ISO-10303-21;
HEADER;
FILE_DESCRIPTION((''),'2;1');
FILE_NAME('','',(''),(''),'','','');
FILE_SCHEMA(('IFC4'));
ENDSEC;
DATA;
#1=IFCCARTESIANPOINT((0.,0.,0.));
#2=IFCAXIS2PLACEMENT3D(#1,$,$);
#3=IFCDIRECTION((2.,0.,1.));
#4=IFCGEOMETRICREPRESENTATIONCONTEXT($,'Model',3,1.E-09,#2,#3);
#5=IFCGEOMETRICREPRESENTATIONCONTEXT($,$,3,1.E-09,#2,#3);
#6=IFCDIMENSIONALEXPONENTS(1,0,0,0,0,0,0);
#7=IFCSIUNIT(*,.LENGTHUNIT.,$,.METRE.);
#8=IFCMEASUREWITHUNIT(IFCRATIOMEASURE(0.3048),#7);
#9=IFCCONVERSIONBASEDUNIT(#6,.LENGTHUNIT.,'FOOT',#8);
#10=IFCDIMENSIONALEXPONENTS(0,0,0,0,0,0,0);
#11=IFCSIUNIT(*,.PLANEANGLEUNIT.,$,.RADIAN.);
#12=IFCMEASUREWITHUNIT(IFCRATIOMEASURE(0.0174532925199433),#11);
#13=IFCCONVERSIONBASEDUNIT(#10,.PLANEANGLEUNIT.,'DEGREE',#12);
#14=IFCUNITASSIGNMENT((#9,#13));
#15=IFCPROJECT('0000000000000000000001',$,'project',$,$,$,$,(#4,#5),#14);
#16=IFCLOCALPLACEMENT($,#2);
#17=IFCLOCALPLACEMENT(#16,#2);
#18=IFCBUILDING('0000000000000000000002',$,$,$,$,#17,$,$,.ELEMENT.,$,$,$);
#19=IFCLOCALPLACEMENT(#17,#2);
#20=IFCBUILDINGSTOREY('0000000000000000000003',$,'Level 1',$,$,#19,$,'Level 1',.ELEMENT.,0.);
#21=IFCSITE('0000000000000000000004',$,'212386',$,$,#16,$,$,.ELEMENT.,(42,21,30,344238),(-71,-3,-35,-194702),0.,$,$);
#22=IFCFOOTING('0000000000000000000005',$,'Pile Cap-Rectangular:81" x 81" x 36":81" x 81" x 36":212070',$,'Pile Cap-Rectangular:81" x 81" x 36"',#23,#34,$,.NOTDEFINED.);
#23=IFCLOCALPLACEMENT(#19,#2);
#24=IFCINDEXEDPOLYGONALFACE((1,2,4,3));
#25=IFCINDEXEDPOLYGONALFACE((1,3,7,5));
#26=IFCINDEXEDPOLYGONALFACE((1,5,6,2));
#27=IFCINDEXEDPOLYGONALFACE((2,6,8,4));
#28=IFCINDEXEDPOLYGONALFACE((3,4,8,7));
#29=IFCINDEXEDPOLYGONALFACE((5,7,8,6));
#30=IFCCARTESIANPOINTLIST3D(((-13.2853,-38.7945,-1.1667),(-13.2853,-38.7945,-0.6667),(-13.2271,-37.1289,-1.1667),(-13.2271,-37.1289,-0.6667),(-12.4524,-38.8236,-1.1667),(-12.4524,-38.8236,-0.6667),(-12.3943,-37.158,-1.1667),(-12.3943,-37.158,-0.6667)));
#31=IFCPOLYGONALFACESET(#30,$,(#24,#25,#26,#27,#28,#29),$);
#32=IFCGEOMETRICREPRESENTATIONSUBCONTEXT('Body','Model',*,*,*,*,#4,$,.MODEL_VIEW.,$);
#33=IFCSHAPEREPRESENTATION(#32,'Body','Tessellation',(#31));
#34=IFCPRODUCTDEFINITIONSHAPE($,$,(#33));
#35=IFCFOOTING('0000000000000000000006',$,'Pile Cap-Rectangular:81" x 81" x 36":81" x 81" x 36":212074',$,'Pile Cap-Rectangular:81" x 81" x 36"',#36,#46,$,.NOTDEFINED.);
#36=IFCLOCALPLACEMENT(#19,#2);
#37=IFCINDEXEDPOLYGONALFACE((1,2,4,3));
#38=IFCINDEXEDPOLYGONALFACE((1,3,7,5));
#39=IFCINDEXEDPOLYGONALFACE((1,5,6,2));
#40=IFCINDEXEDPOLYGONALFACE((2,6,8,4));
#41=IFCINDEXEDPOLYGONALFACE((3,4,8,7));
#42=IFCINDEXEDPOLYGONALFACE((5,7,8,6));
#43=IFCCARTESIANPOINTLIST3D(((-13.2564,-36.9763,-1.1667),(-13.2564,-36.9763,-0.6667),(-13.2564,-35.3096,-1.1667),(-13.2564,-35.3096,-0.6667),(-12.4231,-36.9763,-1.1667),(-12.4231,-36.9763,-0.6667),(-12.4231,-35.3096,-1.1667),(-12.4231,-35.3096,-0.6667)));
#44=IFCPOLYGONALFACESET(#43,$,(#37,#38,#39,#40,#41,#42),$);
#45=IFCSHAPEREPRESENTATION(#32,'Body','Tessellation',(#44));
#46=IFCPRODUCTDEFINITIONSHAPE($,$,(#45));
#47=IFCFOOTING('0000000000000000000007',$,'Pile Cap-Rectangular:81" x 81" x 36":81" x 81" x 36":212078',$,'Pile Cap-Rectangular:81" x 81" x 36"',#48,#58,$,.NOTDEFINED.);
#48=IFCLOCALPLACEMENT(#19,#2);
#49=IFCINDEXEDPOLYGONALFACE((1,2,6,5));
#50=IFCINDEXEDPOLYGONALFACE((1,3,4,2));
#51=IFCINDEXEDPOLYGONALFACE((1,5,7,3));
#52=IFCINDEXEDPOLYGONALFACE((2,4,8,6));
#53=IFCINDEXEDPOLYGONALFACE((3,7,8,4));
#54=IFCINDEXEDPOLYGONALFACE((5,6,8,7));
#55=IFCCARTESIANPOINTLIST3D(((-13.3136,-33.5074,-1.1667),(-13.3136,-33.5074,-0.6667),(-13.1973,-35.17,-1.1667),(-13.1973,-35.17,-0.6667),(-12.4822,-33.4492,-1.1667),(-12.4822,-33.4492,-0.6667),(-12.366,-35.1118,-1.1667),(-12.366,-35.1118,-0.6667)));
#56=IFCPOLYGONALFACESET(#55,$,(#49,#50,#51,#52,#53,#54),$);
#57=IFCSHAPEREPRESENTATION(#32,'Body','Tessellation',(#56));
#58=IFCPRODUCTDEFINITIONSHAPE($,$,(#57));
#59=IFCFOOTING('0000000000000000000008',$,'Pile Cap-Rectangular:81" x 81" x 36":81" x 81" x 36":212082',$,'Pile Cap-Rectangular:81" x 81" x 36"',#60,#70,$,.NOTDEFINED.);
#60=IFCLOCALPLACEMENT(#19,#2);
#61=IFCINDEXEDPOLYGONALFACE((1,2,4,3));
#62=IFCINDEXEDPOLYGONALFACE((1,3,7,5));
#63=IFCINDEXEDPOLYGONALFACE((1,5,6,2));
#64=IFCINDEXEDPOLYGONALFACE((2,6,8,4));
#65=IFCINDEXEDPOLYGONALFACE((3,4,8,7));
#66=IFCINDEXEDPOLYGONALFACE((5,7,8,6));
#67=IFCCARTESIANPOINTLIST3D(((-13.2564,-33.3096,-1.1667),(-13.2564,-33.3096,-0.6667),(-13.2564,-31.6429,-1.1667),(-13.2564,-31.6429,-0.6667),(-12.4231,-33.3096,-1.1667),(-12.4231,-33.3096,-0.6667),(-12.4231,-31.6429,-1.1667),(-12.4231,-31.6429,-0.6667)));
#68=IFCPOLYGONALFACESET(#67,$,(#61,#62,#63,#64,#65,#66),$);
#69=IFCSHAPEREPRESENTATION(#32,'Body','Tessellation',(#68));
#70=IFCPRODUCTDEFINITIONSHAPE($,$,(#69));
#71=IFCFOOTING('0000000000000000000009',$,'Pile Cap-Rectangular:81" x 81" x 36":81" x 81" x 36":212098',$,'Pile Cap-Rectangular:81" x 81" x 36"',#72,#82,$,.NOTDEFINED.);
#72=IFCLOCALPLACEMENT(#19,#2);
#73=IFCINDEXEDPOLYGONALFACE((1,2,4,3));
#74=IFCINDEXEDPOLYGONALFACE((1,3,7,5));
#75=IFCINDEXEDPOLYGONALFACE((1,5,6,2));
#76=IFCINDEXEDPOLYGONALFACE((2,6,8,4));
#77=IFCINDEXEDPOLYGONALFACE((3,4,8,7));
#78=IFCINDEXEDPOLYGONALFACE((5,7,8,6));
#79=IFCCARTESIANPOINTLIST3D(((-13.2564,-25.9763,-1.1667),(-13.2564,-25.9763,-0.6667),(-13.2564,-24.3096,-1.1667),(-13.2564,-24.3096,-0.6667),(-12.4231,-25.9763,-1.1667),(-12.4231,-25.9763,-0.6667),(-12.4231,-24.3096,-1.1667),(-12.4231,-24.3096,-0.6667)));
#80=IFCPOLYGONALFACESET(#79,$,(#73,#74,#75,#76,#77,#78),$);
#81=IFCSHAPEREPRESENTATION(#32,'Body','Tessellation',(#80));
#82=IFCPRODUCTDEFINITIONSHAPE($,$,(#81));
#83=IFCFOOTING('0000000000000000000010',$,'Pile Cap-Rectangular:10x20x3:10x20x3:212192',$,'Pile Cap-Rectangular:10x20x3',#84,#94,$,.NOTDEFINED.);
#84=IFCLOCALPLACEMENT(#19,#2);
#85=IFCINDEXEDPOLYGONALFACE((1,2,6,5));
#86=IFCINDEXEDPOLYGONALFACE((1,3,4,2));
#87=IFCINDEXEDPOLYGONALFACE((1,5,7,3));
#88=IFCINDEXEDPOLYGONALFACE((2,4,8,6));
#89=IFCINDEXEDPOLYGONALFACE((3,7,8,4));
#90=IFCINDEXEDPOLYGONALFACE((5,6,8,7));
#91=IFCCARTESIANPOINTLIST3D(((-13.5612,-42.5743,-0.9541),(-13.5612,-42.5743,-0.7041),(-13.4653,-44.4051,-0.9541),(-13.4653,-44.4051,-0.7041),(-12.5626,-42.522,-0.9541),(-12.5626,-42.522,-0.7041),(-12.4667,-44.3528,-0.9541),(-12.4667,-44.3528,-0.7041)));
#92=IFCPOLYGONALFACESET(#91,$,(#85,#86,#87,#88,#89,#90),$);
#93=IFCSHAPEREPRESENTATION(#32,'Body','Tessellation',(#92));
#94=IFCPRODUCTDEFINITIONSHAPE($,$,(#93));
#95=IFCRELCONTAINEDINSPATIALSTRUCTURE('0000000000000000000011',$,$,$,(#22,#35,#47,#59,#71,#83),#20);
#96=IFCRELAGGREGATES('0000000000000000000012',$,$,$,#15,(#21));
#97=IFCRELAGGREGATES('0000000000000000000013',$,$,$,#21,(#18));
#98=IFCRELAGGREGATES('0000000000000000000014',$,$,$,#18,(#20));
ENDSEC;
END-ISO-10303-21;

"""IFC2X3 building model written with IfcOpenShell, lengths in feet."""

from ifc_helpers import new_model, entity, si_unit, converted_unit, direction, frame, frame_2d, origin, origin_2d_with_axis, place, context, subcontext, project, spatial, rectangle, extrude, element, save


model = new_model("IFC2X3")

# Units and contexts
model_context = context("Model", 3, precision=1e-09, world=origin(), true_north=direction((2.0, 0.0, 1.0)))
context_of_model = context(None, 3, precision=1e-09, world=origin(), true_north=direction((2.0, 0.0, 1.0)))
body_context = subcontext(model_context, "Body", "Model", "MODEL_VIEW")
ifc_project = project(units=[converted_unit("LENGTHUNIT", "FOOT", entity("IfcRatioMeasure", 0.3048), si_unit("LENGTHUNIT", "METRE"), dimensions=[1, 0, 0, 0, 0, 0, 0]), converted_unit("PLANEANGLEUNIT", "DEGREE", entity("IfcRatioMeasure", 0.0174532925199433), si_unit("PLANEANGLEUNIT", "RADIAN"), dimensions=[0, 0, 0, 0, 0, 0, 0])], contexts=[model_context, context_of_model])

# Site, building, storey
site_placement = place(None, origin())
site = spatial("IfcSite", under=ifc_project, at=site_placement, Name="212386", CompositionType="ELEMENT", RefLatitude=(42, 21, 30, 344238), RefLongitude=(-71, -3, -35, -194702), RefElevation=0.0)
building_placement = place(site_placement, origin())
building = spatial("IfcBuilding", under=site, at=building_placement, CompositionType="ELEMENT")
storey_placement = place(building_placement, origin())
storey = spatial("IfcBuildingStorey", under=building, at=storey_placement, Name="Level 1", LongName="Level 1", CompositionType="ELEMENT", Elevation=0.0)

# Footings
footing_1_placement = place(storey_placement, origin())
element("IfcFooting", 1, at=footing_1_placement, inside=storey, Name="Pile Cap-Rectangular:81\" x 81\" x 36\":81\" x 81\" x 36\":212070", ObjectType="Pile Cap-Rectangular:81\" x 81\" x 36\"", PredefinedType="NOTDEFINED", context=body_context, shape_type="SweptSolid", body=[
    extrude(rectangle(XDim=0.8333, YDim=1.6667, at=frame_2d((0.0, 0.0), x_axis=(1.0, 0.0))), frame((-12.8398, -37.9763, -1.1667), z_axis=(0.0, 0.0, 1.0), x_axis=(-0.999391, 0.034899, 0.0)), (0.0, 0.0, 1.0), 0.5),
])
footing_2_placement = place(storey_placement, origin())
element("IfcFooting", 2, at=footing_2_placement, inside=storey, Name="Pile Cap-Rectangular:81\" x 81\" x 36\":81\" x 81\" x 36\":212074", ObjectType="Pile Cap-Rectangular:81\" x 81\" x 36\"", PredefinedType="NOTDEFINED", context=body_context, shape_type="SweptSolid", body=[
    extrude(rectangle(XDim=0.8333, YDim=1.6667, at=frame_2d((0.0, 0.0), x_axis=(1.0, 0.0))), frame((-12.8398, -36.1429, -1.1667), z_axis=(0.0, 0.0, 1.0), x_axis=(-1.0, 0.0, 0.0)), (0.0, 0.0, 1.0), 0.5),
])
footing_3_placement = place(storey_placement, origin())
element("IfcFooting", 3, at=footing_3_placement, inside=storey, Name="Pile Cap-Rectangular:81\" x 81\" x 36\":81\" x 81\" x 36\":212078", ObjectType="Pile Cap-Rectangular:81\" x 81\" x 36\"", PredefinedType="NOTDEFINED", context=body_context, shape_type="SweptSolid", body=[
    extrude(rectangle(XDim=0.8333, YDim=1.6667, at=origin_2d_with_axis()), frame((-12.8398, -34.3096, -1.1667), z_axis=(0.0, 0.0, 1.0), x_axis=(-0.997564, -0.069756, 0.0)), (0.0, 0.0, 1.0), 0.5),
])
footing_4_placement = place(storey_placement, origin())
element("IfcFooting", 4, at=footing_4_placement, inside=storey, Name="Pile Cap-Rectangular:81\" x 81\" x 36\":81\" x 81\" x 36\":212082", ObjectType="Pile Cap-Rectangular:81\" x 81\" x 36\"", PredefinedType="NOTDEFINED", context=body_context, shape_type="SweptSolid", body=[
    extrude(rectangle(XDim=0.8333, YDim=1.6667, at=frame_2d((0.0, 0.0), x_axis=(1.0, 0.0))), frame((-12.8398, -32.4763, -1.1667), z_axis=(0.0, 0.0, 1.0), x_axis=(-1.0, 0.0, 0.0)), (0.0, 0.0, 1.0), 0.5),
])
footing_5_placement = place(storey_placement, origin())
element("IfcFooting", 5, at=footing_5_placement, inside=storey, Name="Pile Cap-Rectangular:81\" x 81\" x 36\":81\" x 81\" x 36\":212098", ObjectType="Pile Cap-Rectangular:81\" x 81\" x 36\"", PredefinedType="NOTDEFINED", context=body_context, shape_type="SweptSolid", body=[
    extrude(rectangle(XDim=0.8333, YDim=1.6667, at=frame_2d((0.0, 0.0), x_axis=(1.0, 0.0))), frame((-12.8398, -25.1429, -1.1667), z_axis=(0.0, 0.0, 1.0), x_axis=(-1.0, 0.0, 0.0)), (0.0, 0.0, 1.0), 0.5),
])
footing_6_placement = place(storey_placement, origin())
element("IfcFooting", 6, at=footing_6_placement, inside=storey, Name="Pile Cap-Rectangular:10x20x3:10x20x3:212192", ObjectType="Pile Cap-Rectangular:10x20x3", PredefinedType="NOTDEFINED", context=body_context, shape_type="SweptSolid", body=[
    extrude(rectangle(XDim=1.0, YDim=1.8333, at=frame_2d((0.0, 0.0), x_axis=(1.0, 0.0))), frame((-13.014, -43.4636, -0.9541), z_axis=(0.0, 0.0, 1.0), x_axis=(-0.99863, -0.052336, 0.0)), (0.0, 0.0, 1.0), 0.25),
])

save(model, "model.ifc")
